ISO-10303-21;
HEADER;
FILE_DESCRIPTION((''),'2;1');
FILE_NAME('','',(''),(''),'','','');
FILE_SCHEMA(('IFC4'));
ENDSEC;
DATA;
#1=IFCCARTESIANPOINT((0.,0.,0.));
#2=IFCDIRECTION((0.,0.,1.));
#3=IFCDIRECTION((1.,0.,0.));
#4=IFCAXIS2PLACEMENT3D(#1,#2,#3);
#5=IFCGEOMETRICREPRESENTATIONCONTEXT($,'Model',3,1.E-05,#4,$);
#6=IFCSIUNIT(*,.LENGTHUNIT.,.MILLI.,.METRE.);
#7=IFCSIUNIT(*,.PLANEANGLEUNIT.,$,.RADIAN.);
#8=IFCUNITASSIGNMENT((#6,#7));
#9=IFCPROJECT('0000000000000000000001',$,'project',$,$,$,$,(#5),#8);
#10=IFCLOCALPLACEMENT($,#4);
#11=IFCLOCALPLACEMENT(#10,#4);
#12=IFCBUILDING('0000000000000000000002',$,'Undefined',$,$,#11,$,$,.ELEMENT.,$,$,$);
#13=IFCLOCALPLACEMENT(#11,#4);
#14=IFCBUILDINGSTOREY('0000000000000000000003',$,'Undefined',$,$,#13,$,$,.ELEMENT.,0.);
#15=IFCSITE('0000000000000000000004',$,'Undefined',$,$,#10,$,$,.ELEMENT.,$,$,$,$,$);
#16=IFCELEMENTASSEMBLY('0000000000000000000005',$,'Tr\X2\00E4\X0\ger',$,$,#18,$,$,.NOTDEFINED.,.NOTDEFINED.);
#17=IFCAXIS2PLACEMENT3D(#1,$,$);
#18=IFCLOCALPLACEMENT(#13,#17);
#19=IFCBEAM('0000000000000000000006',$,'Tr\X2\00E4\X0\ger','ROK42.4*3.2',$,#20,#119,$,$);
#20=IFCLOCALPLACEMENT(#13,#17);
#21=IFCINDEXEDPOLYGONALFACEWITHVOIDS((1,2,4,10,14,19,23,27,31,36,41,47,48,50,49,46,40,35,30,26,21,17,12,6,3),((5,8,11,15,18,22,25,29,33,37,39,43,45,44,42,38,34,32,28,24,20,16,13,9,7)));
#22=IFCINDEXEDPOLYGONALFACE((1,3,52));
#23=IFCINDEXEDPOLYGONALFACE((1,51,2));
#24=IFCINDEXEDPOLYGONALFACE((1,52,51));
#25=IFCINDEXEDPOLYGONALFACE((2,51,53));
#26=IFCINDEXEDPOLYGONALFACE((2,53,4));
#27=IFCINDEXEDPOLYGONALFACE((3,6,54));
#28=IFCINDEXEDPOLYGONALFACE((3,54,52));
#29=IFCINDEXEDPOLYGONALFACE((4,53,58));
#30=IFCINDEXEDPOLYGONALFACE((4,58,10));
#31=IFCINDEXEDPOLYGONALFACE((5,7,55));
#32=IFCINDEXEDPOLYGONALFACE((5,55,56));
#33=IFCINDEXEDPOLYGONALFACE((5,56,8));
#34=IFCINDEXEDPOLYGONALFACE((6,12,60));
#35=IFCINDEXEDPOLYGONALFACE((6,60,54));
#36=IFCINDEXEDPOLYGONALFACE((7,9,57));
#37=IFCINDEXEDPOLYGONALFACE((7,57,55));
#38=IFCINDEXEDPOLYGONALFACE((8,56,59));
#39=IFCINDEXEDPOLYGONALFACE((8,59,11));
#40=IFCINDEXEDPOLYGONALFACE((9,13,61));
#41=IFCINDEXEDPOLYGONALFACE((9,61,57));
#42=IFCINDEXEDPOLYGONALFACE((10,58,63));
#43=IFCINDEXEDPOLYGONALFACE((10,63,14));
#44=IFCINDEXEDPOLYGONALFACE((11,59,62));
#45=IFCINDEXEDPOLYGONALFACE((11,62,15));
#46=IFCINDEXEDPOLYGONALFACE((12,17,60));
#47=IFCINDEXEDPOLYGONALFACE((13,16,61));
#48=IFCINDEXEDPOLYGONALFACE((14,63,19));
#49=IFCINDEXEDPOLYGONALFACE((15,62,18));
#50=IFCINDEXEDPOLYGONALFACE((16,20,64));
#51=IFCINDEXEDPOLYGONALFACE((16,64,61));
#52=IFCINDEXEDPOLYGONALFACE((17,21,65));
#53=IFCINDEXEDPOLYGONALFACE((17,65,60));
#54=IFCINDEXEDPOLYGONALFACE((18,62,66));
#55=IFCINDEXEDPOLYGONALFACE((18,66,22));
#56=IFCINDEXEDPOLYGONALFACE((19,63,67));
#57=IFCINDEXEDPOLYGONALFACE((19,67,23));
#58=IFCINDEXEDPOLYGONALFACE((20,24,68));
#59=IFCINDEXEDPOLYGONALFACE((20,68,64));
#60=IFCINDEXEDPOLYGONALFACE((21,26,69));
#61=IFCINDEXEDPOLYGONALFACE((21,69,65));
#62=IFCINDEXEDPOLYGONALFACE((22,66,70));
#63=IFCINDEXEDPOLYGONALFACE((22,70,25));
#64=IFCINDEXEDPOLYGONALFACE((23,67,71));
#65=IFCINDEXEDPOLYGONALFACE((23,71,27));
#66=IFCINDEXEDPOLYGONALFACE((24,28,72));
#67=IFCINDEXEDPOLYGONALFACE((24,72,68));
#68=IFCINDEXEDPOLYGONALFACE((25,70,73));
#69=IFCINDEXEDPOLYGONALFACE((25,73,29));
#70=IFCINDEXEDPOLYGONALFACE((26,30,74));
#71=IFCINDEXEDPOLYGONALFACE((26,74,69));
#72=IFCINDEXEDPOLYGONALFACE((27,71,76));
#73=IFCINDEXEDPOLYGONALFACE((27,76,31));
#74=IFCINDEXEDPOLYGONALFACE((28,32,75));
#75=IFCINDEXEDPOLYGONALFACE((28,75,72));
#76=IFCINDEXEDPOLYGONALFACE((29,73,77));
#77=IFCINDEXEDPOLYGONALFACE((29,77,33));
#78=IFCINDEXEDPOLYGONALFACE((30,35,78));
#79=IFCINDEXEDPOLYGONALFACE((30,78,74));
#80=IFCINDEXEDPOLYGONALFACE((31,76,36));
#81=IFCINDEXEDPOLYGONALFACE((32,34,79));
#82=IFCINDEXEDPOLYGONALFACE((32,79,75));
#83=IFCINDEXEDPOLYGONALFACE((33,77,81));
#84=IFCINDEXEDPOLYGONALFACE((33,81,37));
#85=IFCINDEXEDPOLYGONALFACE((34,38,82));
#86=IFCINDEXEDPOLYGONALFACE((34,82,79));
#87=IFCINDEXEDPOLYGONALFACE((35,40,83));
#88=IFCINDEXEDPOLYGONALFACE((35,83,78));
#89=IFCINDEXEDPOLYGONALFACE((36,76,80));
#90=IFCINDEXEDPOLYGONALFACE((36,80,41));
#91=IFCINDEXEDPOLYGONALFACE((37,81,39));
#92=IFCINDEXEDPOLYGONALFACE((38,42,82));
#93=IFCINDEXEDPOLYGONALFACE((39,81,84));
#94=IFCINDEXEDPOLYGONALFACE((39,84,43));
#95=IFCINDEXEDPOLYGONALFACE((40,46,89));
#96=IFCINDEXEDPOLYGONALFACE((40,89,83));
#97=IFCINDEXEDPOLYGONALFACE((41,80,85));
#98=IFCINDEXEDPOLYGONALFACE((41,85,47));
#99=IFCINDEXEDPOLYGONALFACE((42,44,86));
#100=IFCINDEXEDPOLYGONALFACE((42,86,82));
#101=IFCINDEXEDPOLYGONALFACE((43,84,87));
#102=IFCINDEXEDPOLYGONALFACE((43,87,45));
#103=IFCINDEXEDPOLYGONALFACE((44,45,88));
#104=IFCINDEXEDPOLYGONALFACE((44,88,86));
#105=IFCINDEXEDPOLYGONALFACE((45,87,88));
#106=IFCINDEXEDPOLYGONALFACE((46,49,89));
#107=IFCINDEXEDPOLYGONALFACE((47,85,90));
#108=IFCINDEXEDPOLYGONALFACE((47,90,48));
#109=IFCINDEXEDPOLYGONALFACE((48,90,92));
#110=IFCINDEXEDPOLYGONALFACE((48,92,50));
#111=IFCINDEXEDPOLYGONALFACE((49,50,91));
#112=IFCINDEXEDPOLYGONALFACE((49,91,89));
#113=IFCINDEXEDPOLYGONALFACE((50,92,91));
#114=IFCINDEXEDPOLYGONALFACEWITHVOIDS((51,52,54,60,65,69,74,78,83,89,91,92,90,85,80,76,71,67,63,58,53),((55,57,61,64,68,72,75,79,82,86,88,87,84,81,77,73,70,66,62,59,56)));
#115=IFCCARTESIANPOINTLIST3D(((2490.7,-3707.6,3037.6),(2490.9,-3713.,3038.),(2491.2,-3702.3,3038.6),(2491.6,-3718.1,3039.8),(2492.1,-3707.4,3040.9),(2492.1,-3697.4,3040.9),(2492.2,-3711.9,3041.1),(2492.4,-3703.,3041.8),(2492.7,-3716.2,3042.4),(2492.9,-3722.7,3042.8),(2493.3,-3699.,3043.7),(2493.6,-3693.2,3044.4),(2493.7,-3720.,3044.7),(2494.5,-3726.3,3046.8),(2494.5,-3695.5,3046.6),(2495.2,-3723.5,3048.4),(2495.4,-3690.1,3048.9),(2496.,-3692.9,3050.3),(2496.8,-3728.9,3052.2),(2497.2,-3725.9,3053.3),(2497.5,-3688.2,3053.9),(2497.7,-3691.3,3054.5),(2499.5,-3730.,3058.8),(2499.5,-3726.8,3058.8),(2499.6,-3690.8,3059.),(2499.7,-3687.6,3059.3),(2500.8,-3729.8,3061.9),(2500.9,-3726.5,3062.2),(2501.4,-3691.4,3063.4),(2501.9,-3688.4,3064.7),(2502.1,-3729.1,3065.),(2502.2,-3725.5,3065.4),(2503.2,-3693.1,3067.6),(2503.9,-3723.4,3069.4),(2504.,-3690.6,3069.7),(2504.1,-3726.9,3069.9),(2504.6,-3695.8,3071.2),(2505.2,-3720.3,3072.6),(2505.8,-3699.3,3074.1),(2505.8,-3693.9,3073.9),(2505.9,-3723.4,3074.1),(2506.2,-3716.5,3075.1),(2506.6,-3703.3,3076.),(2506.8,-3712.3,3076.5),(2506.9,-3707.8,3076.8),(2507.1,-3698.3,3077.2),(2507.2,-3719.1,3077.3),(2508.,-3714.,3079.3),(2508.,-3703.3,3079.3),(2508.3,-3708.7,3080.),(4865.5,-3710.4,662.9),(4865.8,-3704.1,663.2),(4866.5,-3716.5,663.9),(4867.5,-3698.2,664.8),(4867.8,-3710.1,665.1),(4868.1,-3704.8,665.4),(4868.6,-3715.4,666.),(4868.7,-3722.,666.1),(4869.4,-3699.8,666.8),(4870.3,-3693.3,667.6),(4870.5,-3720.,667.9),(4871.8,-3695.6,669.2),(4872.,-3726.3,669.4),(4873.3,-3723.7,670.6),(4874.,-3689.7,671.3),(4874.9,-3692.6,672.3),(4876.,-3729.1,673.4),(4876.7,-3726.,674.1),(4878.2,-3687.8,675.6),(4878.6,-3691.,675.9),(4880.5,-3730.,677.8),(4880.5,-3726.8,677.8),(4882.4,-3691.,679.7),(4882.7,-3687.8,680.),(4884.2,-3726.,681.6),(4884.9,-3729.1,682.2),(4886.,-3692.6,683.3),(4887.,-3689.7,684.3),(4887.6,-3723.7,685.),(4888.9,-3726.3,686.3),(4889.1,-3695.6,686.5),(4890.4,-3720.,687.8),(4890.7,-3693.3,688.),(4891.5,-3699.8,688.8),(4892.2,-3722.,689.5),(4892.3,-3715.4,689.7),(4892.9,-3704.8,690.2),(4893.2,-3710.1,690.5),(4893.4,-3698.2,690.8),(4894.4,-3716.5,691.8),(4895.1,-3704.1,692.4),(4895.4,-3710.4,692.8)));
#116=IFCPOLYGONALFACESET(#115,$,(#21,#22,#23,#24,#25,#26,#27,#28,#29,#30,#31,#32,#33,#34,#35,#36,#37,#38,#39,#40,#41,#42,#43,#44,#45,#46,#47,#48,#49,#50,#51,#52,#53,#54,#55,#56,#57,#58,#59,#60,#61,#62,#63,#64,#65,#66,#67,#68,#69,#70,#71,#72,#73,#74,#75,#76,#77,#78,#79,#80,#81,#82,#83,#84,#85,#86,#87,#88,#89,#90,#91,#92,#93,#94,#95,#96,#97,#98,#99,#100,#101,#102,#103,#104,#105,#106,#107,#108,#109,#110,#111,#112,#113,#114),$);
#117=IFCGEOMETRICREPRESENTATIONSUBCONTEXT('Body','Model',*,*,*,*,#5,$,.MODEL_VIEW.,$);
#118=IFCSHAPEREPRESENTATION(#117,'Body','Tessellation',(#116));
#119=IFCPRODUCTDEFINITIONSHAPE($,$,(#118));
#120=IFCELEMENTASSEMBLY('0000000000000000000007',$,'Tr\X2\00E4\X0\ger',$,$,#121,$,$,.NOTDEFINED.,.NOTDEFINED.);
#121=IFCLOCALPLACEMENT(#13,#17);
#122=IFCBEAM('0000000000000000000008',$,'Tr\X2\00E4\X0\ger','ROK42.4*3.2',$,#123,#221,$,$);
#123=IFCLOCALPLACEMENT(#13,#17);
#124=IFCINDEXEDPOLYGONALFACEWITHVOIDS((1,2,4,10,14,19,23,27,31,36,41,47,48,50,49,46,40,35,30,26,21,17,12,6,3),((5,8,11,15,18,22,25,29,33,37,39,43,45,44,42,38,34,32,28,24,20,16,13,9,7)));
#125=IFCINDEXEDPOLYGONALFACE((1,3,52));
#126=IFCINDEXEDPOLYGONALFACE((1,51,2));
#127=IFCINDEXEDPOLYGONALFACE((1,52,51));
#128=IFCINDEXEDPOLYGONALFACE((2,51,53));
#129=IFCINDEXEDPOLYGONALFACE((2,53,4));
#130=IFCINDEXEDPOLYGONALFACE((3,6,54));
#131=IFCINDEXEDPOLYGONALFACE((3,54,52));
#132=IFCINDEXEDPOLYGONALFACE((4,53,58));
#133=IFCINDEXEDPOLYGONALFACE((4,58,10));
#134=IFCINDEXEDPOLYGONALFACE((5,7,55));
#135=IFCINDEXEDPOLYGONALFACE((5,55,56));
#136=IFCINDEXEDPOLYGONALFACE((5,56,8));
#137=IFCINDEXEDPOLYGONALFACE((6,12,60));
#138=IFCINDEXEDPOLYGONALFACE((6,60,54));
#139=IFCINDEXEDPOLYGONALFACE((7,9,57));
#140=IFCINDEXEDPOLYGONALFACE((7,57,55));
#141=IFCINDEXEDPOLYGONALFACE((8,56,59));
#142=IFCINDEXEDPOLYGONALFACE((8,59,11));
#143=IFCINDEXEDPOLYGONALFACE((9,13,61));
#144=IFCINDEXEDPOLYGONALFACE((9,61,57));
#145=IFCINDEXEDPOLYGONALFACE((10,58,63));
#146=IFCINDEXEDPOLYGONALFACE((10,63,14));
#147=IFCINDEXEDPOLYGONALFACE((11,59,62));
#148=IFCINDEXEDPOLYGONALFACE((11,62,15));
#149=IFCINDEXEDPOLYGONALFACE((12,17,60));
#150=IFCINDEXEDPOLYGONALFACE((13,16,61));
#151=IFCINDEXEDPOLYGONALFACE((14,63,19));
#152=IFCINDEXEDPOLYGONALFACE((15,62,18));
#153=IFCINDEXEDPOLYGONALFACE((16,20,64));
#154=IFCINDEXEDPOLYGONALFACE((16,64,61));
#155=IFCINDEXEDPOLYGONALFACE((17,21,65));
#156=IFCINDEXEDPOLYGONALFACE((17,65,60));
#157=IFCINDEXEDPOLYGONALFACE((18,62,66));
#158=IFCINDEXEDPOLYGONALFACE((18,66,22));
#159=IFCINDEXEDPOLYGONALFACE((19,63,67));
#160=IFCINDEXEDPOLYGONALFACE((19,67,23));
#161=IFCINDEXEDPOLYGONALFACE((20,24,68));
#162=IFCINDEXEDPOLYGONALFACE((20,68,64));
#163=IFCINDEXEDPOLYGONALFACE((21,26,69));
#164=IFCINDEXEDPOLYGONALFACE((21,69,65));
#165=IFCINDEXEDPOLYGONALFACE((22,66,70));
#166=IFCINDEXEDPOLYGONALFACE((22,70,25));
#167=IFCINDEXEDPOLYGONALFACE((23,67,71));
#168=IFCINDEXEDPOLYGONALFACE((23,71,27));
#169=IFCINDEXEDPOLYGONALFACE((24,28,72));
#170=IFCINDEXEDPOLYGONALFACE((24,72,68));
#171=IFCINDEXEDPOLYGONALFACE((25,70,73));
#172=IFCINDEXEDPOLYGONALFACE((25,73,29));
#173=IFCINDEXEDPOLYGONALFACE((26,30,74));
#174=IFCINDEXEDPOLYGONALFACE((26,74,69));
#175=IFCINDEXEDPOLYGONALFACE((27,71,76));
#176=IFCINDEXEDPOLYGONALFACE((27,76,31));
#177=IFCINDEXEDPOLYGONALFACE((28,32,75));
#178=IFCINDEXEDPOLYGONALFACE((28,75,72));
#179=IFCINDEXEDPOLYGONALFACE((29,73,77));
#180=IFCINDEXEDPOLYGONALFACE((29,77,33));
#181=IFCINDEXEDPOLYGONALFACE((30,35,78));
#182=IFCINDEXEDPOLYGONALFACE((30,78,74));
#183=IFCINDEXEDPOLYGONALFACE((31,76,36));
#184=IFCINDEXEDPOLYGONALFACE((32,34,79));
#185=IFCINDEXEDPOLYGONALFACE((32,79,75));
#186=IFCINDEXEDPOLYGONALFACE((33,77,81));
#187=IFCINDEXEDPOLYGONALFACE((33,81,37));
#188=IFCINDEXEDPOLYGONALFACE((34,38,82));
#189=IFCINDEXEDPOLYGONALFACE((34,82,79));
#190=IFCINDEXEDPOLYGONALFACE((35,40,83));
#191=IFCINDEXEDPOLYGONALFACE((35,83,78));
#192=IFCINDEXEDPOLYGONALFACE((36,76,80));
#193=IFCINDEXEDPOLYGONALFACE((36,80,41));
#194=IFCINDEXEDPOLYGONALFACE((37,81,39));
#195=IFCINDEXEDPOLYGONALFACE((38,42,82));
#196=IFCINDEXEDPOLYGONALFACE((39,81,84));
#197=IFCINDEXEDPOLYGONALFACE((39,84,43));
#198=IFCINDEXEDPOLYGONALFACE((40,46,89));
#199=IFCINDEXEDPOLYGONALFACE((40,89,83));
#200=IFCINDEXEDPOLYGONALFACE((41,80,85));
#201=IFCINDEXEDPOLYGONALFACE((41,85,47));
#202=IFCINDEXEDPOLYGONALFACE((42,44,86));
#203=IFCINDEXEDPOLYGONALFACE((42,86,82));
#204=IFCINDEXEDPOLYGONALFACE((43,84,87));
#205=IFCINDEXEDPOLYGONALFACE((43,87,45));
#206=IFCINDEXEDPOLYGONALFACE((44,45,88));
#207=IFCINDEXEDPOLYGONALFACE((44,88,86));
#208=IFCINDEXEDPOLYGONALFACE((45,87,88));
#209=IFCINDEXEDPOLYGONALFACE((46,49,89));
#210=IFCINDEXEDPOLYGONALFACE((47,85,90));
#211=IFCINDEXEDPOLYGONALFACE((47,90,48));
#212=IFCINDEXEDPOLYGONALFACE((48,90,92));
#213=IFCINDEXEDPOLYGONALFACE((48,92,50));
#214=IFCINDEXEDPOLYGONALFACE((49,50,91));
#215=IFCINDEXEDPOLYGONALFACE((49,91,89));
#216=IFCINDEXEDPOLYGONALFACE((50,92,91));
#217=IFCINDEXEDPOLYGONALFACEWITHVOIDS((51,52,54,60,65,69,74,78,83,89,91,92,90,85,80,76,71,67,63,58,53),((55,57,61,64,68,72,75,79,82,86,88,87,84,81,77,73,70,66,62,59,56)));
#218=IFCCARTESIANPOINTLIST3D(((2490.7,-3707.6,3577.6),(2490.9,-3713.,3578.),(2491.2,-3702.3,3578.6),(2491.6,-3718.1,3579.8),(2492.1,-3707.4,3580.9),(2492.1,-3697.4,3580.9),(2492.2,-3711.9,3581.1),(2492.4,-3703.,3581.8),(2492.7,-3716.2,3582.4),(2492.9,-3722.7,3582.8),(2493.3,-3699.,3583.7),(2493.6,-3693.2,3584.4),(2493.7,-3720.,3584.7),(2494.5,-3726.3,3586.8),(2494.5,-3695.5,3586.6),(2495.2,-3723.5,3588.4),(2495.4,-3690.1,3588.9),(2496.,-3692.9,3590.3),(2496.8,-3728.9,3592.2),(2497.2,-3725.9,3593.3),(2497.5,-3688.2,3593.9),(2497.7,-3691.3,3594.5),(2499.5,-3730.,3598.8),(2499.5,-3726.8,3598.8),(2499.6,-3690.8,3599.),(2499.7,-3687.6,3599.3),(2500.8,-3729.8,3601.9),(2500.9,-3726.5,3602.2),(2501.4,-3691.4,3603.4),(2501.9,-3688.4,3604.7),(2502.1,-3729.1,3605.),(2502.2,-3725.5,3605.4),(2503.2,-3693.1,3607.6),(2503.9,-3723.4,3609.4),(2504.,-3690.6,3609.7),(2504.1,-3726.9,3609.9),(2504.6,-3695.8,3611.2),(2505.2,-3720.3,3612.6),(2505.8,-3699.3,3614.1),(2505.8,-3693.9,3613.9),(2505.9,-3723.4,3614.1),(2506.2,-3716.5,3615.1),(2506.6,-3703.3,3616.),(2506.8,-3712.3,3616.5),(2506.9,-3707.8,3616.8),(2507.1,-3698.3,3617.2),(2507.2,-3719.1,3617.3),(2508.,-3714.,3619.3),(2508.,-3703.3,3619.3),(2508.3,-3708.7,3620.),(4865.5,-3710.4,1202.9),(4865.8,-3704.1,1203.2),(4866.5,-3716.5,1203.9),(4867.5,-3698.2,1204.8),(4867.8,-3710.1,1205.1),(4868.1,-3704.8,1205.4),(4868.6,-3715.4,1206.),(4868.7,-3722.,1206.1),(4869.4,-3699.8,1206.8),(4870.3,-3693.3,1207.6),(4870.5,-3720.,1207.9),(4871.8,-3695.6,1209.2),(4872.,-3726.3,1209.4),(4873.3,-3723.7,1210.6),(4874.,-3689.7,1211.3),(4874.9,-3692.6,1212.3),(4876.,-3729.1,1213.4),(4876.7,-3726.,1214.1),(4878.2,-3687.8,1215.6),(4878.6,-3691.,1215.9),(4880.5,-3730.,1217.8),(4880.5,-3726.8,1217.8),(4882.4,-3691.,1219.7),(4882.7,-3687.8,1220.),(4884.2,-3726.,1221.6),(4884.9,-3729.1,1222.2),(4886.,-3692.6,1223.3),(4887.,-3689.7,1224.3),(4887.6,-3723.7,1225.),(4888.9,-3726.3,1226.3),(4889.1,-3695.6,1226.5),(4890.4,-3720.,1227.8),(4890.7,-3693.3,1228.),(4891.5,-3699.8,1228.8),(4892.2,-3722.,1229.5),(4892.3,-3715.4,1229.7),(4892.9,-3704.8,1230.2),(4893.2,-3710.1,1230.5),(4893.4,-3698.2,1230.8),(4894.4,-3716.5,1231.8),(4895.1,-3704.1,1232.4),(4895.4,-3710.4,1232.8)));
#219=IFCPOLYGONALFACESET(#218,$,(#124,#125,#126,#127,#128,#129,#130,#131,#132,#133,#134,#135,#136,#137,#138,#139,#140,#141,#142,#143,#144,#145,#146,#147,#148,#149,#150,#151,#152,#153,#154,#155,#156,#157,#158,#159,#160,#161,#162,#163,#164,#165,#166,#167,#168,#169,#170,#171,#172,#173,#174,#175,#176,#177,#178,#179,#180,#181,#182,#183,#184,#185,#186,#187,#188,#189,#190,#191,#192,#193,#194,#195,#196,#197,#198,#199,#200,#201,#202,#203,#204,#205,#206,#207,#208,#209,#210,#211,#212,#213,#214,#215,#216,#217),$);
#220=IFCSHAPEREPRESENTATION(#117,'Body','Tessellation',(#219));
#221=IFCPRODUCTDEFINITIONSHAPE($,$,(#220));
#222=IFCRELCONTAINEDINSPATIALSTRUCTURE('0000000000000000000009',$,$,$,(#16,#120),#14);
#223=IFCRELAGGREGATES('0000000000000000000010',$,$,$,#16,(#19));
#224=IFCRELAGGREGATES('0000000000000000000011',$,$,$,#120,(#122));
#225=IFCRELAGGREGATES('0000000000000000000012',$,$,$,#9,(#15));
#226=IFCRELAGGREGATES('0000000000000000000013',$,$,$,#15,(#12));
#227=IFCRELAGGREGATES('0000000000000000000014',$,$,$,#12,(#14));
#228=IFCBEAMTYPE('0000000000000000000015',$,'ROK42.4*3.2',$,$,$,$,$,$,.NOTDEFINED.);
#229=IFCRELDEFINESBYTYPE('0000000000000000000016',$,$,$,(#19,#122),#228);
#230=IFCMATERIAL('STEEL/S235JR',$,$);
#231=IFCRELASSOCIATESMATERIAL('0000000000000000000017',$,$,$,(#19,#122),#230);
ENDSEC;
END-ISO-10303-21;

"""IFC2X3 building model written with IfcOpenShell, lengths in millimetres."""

from ifc_helpers import new_model, si_unit, frame, origin_with_axes, origin_2d_with_axis, place, context, subcontext, project, spatial, hollow_circle, extrude, clip, halfspace, material, type_object, element, aggregate, save


model = new_model("IFC2X3")

# Units and contexts
model_context = context("Model", 3, precision=1e-05, world=origin_with_axes())
body_context = subcontext(model_context, "Body", "Model", "MODEL_VIEW")
ifc_project = project(units=[si_unit("LENGTHUNIT", "METRE", prefix="MILLI"), si_unit("PLANEANGLEUNIT", "RADIAN")], contexts=[model_context])

# Site, building, storey
site_placement = place(None, origin_with_axes())
site = spatial("IfcSite", under=ifc_project, at=site_placement, Name="Undefined", CompositionType="ELEMENT")
building_placement = place(site_placement, origin_with_axes())
building = spatial("IfcBuilding", under=site, at=building_placement, Name="Undefined", CompositionType="ELEMENT")
storey_placement = place(building_placement, origin_with_axes())
storey = spatial("IfcBuildingStorey", under=building, at=storey_placement, Name="Undefined", CompositionType="ELEMENT", Elevation=0.0)

# Shared definitions
ifc_material_1 = material(Name="STEEL/S235JR")
beam_type = type_object("IfcBeamType", Name="ROK42.4*3.2", PredefinedType="NOTDEFINED")

# Element assemblies, beams
assembly_1_placement = place(storey_placement, origin_with_axes())
assembly_1 = element("IfcElementAssembly", 1, at=assembly_1_placement, inside=storey, Name="Träger", AssemblyPlace="NOTDEFINED", PredefinedType="NOTDEFINED")
beam_1_placement = place(assembly_1_placement, frame((2493.3, -3708.8, 3065.0), z_axis=(0.707111, 0.0, 0.707103), x_axis=(0.707103, 0.0, -0.707111)))
beam_1 = element("IfcBeam", 2, at=beam_1_placement, type_object=beam_type, material=ifc_material_1, Name="Träger", Description="ROK42.4*3.2", context=body_context, shape_type="Clipping", body=[
    clip(extrude(hollow_circle(Radius=21.2, WallThickness=3.2, at=origin_2d_with_axis()), frame((3376.0, 0.0, 0.0), z_axis=(-1.0, 0.0, 0.0), x_axis=(0.0, -1.0, 0.0)), (0.0, 0.0, 1.0), 3410.0), halfspace(frame((0.0, 0.0, 21.2), z_axis=(0.923878, 0.0, 0.382686), x_axis=(0.0, 1.0, 0.0)), True)),
])
assembly_2_placement = place(storey_placement, origin_with_axes())
assembly_2 = element("IfcElementAssembly", 3, at=assembly_2_placement, inside=storey, Name="Träger", AssemblyPlace="NOTDEFINED", PredefinedType="NOTDEFINED")
beam_2_placement = place(assembly_2_placement, frame((2493.3, -3708.8, 3605.0), z_axis=(0.707111, 0.0, 0.707103), x_axis=(0.707103, 0.0, -0.707111)))
beam_2 = element("IfcBeam", 4, at=beam_2_placement, type_object=beam_type, material=ifc_material_1, Name="Träger", Description="ROK42.4*3.2", context=body_context, shape_type="Clipping", body=[
    clip(extrude(hollow_circle(Radius=21.2, WallThickness=3.2, at=origin_2d_with_axis()), frame((3376.0, 0.0, 0.0), z_axis=(-1.0, 0.0, 0.0), x_axis=(0.0, -1.0, 0.0)), (0.0, 0.0, 1.0), 3410.0), halfspace(frame((0.0, 0.0, 21.2), z_axis=(0.923878, 0.0, 0.382686), x_axis=(0.0, 1.0, 0.0)), True)),
])

aggregate(assembly_1, [beam_1])
aggregate(assembly_2, [beam_2])

save(model, "model.ifc")
